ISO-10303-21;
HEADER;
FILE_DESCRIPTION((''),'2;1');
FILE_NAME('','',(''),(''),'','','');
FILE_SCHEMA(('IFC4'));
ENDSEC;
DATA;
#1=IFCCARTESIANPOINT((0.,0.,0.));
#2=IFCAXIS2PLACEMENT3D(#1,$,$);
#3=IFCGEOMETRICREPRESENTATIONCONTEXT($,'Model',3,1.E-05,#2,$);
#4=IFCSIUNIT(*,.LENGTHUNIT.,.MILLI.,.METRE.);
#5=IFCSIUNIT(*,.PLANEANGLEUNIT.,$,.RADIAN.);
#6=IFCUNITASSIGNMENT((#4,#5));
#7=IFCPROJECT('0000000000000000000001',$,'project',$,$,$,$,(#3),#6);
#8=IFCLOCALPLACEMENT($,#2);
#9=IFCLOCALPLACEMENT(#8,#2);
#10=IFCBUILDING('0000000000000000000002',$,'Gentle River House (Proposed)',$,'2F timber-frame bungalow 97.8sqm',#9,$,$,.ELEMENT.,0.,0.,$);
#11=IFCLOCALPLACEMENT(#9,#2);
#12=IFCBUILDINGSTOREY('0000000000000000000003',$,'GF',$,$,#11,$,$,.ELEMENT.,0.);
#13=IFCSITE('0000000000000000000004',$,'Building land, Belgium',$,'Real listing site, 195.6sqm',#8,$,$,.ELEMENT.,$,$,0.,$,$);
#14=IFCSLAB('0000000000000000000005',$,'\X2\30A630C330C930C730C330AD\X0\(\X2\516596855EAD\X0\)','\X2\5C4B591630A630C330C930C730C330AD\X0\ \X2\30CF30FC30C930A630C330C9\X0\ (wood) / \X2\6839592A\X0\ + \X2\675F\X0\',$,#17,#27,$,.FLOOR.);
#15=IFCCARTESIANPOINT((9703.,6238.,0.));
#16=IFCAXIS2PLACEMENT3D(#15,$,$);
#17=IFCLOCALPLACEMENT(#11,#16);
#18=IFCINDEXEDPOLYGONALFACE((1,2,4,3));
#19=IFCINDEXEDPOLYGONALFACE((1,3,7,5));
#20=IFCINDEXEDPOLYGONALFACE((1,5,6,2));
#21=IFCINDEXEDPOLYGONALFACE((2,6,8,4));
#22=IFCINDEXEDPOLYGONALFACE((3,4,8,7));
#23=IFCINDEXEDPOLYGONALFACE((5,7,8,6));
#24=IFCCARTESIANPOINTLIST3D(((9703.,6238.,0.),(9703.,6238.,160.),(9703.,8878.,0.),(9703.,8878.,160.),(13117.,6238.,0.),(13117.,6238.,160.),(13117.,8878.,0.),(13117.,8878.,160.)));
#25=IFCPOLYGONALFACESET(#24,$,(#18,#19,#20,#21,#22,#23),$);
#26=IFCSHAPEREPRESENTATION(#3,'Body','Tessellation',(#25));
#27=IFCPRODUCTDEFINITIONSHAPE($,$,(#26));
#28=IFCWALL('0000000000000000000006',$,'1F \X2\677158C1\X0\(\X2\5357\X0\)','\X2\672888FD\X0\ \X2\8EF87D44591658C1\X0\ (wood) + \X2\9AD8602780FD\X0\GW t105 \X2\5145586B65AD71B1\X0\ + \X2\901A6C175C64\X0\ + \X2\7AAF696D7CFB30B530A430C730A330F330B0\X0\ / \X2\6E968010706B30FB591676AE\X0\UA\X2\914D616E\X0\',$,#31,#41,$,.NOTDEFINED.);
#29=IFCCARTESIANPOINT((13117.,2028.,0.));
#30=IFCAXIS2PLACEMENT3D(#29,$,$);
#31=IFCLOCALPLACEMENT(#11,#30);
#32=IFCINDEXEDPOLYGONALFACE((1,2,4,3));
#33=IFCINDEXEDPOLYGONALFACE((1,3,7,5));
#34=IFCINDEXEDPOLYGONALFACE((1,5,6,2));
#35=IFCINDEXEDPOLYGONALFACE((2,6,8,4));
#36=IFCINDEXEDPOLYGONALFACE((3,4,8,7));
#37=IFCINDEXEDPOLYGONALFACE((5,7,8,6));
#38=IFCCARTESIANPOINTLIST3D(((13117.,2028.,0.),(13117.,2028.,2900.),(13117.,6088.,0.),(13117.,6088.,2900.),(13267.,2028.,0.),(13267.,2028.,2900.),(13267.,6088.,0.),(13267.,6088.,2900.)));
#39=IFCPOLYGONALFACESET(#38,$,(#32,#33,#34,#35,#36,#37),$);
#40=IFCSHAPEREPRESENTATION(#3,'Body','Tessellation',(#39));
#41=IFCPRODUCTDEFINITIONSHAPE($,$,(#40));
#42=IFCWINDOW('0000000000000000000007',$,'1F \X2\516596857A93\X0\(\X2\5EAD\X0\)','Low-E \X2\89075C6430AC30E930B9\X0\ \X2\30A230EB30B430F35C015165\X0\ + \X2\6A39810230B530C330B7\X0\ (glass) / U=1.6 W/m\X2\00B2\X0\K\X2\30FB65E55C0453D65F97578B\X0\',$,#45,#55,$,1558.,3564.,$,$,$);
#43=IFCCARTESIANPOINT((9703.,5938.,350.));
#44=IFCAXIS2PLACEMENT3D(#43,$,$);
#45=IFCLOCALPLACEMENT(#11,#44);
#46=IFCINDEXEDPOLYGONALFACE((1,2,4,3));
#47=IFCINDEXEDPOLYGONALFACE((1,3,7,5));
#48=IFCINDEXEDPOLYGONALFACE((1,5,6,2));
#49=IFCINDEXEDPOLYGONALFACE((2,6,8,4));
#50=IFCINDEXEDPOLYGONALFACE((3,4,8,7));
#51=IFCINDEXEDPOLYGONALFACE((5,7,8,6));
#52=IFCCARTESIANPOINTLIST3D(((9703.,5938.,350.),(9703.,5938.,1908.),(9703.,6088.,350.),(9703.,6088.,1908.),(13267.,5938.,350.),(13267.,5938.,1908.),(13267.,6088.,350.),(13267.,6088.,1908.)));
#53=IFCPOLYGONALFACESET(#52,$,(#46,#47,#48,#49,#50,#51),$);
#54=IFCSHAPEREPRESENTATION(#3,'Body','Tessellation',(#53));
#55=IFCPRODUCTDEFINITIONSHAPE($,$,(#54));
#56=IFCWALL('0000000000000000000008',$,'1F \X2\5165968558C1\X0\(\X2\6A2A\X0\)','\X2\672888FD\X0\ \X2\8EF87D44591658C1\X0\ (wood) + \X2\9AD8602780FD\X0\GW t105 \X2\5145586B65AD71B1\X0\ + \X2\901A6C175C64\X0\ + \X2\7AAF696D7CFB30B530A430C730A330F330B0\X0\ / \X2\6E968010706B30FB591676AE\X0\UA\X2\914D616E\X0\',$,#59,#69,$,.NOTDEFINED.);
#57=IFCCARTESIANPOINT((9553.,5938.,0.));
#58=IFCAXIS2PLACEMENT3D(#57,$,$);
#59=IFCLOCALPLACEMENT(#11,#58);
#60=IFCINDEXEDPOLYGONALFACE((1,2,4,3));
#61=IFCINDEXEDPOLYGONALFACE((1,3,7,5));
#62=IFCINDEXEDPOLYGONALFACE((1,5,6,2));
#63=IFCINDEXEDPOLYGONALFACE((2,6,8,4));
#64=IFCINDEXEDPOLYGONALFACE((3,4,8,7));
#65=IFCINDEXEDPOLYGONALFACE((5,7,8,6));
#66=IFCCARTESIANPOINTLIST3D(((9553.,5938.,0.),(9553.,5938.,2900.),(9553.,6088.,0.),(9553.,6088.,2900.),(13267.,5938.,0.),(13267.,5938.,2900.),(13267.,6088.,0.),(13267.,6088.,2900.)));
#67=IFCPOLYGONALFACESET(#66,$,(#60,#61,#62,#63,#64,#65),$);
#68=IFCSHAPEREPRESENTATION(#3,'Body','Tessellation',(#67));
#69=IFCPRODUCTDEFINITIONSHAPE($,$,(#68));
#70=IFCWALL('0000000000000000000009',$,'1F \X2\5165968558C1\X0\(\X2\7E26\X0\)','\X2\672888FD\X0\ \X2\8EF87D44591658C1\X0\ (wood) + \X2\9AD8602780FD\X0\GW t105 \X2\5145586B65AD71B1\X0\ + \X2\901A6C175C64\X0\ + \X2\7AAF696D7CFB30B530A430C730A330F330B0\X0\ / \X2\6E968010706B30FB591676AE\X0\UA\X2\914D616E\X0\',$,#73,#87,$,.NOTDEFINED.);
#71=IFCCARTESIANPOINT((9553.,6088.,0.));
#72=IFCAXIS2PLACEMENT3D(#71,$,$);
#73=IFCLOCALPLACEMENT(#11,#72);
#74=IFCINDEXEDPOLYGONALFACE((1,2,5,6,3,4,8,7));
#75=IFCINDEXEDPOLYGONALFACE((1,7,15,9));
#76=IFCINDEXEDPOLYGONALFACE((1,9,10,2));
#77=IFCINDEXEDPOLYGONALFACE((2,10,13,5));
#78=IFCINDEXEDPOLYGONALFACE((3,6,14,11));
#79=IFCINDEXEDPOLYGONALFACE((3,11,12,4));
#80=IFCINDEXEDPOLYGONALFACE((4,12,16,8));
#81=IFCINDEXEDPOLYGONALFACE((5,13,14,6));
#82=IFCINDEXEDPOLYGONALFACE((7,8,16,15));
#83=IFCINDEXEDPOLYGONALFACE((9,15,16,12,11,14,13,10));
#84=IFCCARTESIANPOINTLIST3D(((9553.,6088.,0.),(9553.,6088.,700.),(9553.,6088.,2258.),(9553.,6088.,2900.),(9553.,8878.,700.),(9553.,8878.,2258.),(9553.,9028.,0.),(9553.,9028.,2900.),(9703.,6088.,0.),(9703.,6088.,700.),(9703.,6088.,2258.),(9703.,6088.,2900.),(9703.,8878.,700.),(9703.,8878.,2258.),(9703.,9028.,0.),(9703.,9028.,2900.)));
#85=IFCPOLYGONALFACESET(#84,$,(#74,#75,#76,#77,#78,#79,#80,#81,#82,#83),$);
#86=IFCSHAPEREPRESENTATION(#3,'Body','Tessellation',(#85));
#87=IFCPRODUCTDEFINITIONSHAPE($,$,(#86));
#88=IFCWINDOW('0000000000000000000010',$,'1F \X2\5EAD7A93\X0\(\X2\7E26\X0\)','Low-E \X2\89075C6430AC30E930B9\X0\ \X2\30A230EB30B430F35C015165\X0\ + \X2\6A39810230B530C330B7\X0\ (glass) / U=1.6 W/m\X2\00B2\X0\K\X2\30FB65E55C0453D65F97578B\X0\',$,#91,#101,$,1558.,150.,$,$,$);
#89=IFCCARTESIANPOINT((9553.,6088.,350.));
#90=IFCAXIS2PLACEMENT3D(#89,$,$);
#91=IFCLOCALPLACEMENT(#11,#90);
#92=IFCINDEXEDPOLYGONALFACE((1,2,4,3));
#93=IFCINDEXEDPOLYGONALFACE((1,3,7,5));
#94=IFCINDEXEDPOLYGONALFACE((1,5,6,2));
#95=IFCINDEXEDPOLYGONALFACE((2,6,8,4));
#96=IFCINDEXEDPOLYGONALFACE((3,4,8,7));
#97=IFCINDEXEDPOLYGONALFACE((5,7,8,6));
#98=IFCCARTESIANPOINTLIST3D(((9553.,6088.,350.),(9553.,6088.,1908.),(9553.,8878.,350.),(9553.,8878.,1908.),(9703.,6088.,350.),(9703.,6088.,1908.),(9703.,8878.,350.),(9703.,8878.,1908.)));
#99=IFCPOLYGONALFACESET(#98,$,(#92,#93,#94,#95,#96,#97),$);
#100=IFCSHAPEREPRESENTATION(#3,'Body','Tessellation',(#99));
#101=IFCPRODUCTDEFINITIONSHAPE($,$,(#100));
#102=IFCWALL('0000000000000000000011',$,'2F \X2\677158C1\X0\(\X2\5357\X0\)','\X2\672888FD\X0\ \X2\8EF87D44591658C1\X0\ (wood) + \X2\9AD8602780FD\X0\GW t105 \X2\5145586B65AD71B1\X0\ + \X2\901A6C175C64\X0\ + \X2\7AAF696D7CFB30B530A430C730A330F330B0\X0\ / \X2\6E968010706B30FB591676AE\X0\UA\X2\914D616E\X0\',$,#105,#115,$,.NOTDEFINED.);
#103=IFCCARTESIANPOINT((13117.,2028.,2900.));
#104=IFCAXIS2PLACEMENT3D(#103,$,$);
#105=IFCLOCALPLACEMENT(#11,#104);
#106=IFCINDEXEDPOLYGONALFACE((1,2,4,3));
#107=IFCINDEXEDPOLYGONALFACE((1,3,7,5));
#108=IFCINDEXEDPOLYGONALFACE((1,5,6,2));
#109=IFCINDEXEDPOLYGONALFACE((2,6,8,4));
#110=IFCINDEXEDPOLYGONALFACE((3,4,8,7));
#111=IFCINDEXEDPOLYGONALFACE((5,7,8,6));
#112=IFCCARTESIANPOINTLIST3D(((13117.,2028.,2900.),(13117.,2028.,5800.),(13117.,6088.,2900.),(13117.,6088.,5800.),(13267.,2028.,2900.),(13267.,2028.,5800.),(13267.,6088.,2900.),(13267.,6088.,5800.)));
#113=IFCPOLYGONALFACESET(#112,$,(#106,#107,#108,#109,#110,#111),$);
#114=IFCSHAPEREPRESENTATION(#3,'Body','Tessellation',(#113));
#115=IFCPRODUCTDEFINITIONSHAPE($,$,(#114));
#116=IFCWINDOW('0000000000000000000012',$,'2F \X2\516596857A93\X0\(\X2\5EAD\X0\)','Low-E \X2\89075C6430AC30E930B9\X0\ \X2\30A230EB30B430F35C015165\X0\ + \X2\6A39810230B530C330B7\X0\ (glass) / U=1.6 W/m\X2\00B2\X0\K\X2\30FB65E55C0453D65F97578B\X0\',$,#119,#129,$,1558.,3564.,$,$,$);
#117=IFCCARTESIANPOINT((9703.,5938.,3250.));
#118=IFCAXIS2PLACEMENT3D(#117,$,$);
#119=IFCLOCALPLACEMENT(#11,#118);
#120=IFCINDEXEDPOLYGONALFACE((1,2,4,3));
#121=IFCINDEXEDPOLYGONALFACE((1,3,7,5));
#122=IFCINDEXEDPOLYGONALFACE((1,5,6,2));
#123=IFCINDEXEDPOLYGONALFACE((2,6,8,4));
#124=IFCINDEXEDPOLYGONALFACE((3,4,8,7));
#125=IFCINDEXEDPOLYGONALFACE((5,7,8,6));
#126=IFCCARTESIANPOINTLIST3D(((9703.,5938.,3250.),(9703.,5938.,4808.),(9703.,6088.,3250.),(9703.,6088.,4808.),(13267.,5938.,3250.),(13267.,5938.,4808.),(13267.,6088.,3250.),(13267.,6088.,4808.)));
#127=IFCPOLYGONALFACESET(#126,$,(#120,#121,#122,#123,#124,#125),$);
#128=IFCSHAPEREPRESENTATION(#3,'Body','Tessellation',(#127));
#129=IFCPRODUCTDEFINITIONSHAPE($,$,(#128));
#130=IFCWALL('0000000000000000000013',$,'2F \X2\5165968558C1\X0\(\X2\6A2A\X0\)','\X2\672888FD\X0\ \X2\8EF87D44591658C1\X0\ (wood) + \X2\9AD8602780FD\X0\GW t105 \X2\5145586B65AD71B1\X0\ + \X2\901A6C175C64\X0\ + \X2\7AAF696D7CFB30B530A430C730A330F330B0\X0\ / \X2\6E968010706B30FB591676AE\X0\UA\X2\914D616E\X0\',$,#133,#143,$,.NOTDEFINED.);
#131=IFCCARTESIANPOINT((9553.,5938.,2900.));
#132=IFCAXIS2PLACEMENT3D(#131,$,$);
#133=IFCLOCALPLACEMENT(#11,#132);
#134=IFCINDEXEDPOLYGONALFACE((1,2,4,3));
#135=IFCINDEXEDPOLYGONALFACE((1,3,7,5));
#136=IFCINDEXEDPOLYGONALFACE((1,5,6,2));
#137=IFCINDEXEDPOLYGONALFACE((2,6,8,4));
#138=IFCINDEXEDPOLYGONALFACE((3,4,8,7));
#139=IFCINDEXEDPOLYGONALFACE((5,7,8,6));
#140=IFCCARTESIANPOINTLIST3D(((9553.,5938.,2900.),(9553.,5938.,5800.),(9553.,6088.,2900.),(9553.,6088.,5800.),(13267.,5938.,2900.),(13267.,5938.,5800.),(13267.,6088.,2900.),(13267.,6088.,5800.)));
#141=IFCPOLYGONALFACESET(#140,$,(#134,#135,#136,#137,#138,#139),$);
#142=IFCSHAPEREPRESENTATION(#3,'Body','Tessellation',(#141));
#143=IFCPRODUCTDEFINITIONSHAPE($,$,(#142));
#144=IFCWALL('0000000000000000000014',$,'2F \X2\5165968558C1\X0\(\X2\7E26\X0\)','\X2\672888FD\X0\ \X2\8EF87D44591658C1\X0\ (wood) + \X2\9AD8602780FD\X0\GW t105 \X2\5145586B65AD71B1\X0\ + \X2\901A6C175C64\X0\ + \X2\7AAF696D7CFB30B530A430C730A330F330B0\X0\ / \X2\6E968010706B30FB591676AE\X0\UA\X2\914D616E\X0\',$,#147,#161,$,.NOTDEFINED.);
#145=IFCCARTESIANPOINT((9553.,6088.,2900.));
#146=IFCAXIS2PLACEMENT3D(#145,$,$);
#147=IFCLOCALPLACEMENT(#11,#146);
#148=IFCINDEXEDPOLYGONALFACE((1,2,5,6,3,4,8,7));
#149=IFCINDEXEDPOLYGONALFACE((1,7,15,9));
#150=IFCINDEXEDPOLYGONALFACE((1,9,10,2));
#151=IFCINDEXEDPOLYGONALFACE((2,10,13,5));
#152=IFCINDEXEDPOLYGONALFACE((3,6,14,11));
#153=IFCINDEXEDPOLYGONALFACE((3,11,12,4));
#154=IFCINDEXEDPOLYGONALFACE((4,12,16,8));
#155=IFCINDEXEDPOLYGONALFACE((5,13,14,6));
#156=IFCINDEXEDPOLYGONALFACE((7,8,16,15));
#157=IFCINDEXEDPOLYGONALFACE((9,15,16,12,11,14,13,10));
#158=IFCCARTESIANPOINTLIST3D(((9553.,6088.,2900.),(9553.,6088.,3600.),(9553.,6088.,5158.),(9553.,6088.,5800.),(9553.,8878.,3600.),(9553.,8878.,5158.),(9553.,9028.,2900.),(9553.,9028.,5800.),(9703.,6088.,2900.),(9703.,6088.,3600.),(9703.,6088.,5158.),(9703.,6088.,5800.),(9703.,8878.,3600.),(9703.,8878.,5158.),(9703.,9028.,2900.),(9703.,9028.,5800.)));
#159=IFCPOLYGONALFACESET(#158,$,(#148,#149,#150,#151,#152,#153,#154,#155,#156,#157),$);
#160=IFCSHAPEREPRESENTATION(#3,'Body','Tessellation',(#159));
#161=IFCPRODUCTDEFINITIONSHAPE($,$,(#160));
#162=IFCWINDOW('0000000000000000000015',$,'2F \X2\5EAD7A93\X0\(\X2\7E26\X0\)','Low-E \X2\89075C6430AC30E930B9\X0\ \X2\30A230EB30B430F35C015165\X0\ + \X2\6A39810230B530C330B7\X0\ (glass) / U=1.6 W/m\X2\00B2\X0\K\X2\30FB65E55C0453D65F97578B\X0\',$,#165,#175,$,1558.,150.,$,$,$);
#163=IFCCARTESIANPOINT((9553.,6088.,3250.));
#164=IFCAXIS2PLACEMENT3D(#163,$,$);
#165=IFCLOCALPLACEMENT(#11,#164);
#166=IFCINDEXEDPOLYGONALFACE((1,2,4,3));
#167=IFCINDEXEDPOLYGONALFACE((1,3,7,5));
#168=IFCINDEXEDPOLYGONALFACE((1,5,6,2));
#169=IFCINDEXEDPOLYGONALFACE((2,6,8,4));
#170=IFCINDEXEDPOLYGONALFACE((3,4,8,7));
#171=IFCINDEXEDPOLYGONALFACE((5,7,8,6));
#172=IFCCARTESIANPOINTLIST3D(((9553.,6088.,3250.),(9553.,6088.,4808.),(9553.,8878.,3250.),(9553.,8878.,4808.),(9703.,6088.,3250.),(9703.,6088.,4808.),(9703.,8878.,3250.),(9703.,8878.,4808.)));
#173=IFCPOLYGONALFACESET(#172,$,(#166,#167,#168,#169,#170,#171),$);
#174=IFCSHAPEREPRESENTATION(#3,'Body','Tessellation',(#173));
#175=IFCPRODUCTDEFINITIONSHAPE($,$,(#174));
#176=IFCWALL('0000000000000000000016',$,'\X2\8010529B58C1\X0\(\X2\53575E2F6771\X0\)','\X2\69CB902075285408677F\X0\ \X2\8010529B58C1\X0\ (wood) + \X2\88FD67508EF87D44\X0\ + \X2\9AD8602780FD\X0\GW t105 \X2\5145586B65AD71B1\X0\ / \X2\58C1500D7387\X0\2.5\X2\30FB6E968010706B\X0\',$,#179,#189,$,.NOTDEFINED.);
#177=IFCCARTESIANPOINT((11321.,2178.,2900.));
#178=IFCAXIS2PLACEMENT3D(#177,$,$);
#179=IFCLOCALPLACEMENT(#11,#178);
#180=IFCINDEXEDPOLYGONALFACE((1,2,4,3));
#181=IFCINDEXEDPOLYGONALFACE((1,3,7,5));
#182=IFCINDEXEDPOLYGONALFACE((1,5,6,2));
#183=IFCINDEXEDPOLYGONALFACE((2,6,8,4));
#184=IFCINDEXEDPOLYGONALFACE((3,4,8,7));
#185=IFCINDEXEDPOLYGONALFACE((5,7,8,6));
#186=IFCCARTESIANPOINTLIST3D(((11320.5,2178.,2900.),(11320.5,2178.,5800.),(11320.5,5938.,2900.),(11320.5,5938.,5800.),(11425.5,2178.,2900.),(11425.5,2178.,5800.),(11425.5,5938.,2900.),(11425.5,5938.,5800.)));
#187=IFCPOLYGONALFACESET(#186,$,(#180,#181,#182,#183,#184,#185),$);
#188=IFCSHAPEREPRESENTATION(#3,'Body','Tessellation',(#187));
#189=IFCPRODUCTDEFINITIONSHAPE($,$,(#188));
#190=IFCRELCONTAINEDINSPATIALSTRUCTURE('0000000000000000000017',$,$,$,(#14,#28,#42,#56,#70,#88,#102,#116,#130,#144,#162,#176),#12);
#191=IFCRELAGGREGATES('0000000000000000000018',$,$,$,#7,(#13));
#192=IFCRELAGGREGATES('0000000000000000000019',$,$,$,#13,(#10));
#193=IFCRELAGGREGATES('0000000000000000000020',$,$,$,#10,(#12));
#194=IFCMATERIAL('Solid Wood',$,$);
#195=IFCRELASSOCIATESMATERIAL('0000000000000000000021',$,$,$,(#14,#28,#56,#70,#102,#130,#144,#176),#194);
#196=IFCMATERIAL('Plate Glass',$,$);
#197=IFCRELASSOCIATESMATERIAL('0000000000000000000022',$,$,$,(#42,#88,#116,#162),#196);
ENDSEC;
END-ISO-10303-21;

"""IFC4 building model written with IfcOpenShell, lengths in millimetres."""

from ifc_helpers import new_model, si_unit, frame, frame_2d, origin, place, context, project, spatial, rectangle, extrude, material, element, fill, save


model = new_model("IFC4")

# Units and contexts
model_context = context("Model", 3, precision=1e-05, world=origin())
ifc_project = project(units=[si_unit("LENGTHUNIT", "METRE", prefix="MILLI"), si_unit("PLANEANGLEUNIT", "RADIAN")], contexts=[model_context])

# Site, building, storey
site_placement = place(None, origin())
site = spatial("IfcSite", under=ifc_project, at=site_placement, Name="Building land, Belgium", ObjectType="Real listing site, 195.6sqm", CompositionType="ELEMENT", RefElevation=0.0)
building_placement = place(site_placement, origin())
building = spatial("IfcBuilding", under=site, at=building_placement, Name="Gentle River House (Proposed)", ObjectType="2F timber-frame bungalow 97.8sqm", CompositionType="ELEMENT", ElevationOfRefHeight=0.0, ElevationOfTerrain=0.0)
storey_placement = place(building_placement, origin())
storey = spatial("IfcBuildingStorey", under=building, at=storey_placement, Name="GF", CompositionType="ELEMENT", Elevation=0.0)

# Slab
ifc_material_1 = material(Name="Solid Wood")
slab_placement = place(storey_placement, frame((9703.0, 6238.0, 0.0)))
element("IfcSlab", 1, at=slab_placement, inside=storey, material=ifc_material_1, Name="ウッドデッキ(入隅庭)", Description="屋外ウッドデッキ ハードウッド (wood) / 根太 + 束", PredefinedType="FLOOR", context=model_context, shape_type="SweptSolid", body=[
    extrude(rectangle(XDim=3414.0, YDim=2640.0, at=frame_2d((1707.0, 1320.0))), frame((9703.0, 6238.0, 0.0)), (0.0, 0.0, 1.0), 160.0),
])

# Wall, opening, window
wall_1_placement = place(storey_placement, frame((13117.0, 2028.0, 0.0)))
wall_1 = element("IfcWall", 2, at=wall_1_placement, inside=storey, material=ifc_material_1, Name="1F 東壁(南)", Description="木製 軸組外壁 (wood) + 高性能GW t105 充填断熱 + 通気層 + 窯業系サイディング / 準耐火・外皮UA配慮", PredefinedType="NOTDEFINED", context=model_context, shape_type="SweptSolid", body=[
    extrude(rectangle(XDim=150.0, YDim=4060.0, at=frame_2d((75.0, 2030.0))), frame((13117.0, 2028.0, 0.0)), (0.0, 0.0, 1.0), 2900.0),
])
opening_1_placement = place(storey_placement, frame((9703.0, 5938.0, 350.0)))
opening_1 = element("IfcOpeningElement", 3, at=opening_1_placement, cuts=wall_1, PredefinedType="NOTDEFINED", context=model_context, shape_type="SweptSolid", body=[
    extrude(rectangle(XDim=3564.0, YDim=150.0, at=frame_2d((1782.0, 75.0))), frame((9703.0, 5938.0, 350.0)), (0.0, 0.0, 1.0), 1558.0),
])
ifc_material_2 = material(Name="Plate Glass")
window_1_placement = place(storey_placement, frame((9703.0, 5938.0, 350.0)))
window_1 = element("IfcWindow", 4, at=window_1_placement, inside=storey, material=ifc_material_2, Name="1F 入隅窓(庭)", Description="Low-E 複層ガラス アルゴン封入 + 樹脂サッシ (glass) / U=1.6 W/m²K・日射取得型", OverallHeight=1558.0, OverallWidth=3564.0, context=model_context, shape_type="SweptSolid", body=[
    extrude(rectangle(XDim=3564.0, YDim=150.0, at=frame_2d((1782.0, 75.0))), frame((9703.0, 5938.0, 350.0)), (0.0, 0.0, 1.0), 1558.0),
])
fill(opening_1, window_1)

# Wall
wall_2_placement = place(storey_placement, frame((9553.0, 5938.0, 0.0)))
element("IfcWall", 5, at=wall_2_placement, inside=storey, material=ifc_material_1, Name="1F 入隅壁(横)", Description="木製 軸組外壁 (wood) + 高性能GW t105 充填断熱 + 通気層 + 窯業系サイディング / 準耐火・外皮UA配慮", PredefinedType="NOTDEFINED", context=model_context, shape_type="SweptSolid", body=[
    extrude(rectangle(XDim=3714.0, YDim=150.0, at=frame_2d((1857.0, 75.0))), frame((9553.0, 5938.0, 0.0)), (0.0, 0.0, 1.0), 2900.0),
])

# Wall, opening, window
wall_3_placement = place(storey_placement, frame((9553.0, 6088.0, 0.0)))
wall_3 = element("IfcWall", 6, at=wall_3_placement, inside=storey, material=ifc_material_1, Name="1F 入隅壁(縦)", Description="木製 軸組外壁 (wood) + 高性能GW t105 充填断熱 + 通気層 + 窯業系サイディング / 準耐火・外皮UA配慮", PredefinedType="NOTDEFINED", context=model_context, shape_type="SweptSolid", body=[
    extrude(rectangle(XDim=150.0, YDim=2940.0, at=frame_2d((75.0, 1470.0))), frame((9553.0, 6088.0, 0.0)), (0.0, 0.0, 1.0), 2900.0),
])
opening_2_placement = place(storey_placement, frame((9553.0, 6088.0, 350.0)))
opening_2 = element("IfcOpeningElement", 7, at=opening_2_placement, cuts=wall_3, PredefinedType="NOTDEFINED", context=model_context, shape_type="SweptSolid", body=[
    extrude(rectangle(XDim=150.0, YDim=2790.0, at=frame_2d((75.0, 1395.0))), frame((9553.0, 6088.0, 350.0)), (0.0, 0.0, 1.0), 1558.0),
])
window_2_placement = place(storey_placement, frame((9553.0, 6088.0, 350.0)))
window_2 = element("IfcWindow", 8, at=window_2_placement, inside=storey, material=ifc_material_2, Name="1F 庭窓(縦)", Description="Low-E 複層ガラス アルゴン封入 + 樹脂サッシ (glass) / U=1.6 W/m²K・日射取得型", OverallHeight=1558.0, OverallWidth=150.0, context=model_context, shape_type="SweptSolid", body=[
    extrude(rectangle(XDim=150.0, YDim=2790.0, at=frame_2d((75.0, 1395.0))), frame((9553.0, 6088.0, 350.0)), (0.0, 0.0, 1.0), 1558.0),
])
fill(opening_2, window_2)

# Wall, opening, window
wall_4_placement = place(storey_placement, frame((13117.0, 2028.0, 2900.0)))
wall_4 = element("IfcWall", 9, at=wall_4_placement, inside=storey, material=ifc_material_1, Name="2F 東壁(南)", Description="木製 軸組外壁 (wood) + 高性能GW t105 充填断熱 + 通気層 + 窯業系サイディング / 準耐火・外皮UA配慮", PredefinedType="NOTDEFINED", context=model_context, shape_type="SweptSolid", body=[
    extrude(rectangle(XDim=150.0, YDim=4060.0, at=frame_2d((75.0, 2030.0))), frame((13117.0, 2028.0, 2900.0)), (0.0, 0.0, 1.0), 2900.0),
])
opening_3_placement = place(storey_placement, frame((9703.0, 5938.0, 3250.0)))
opening_3 = element("IfcOpeningElement", 10, at=opening_3_placement, cuts=wall_4, PredefinedType="NOTDEFINED", context=model_context, shape_type="SweptSolid", body=[
    extrude(rectangle(XDim=3564.0, YDim=150.0, at=frame_2d((1782.0, 75.0))), frame((9703.0, 5938.0, 3250.0)), (0.0, 0.0, 1.0), 1558.0),
])
window_3_placement = place(storey_placement, frame((9703.0, 5938.0, 3250.0)))
window_3 = element("IfcWindow", 11, at=window_3_placement, inside=storey, material=ifc_material_2, Name="2F 入隅窓(庭)", Description="Low-E 複層ガラス アルゴン封入 + 樹脂サッシ (glass) / U=1.6 W/m²K・日射取得型", OverallHeight=1558.0, OverallWidth=3564.0, context=model_context, shape_type="SweptSolid", body=[
    extrude(rectangle(XDim=3564.0, YDim=150.0, at=frame_2d((1782.0, 75.0))), frame((9703.0, 5938.0, 3250.0)), (0.0, 0.0, 1.0), 1558.0),
])
fill(opening_3, window_3)

# Wall
wall_5_placement = place(storey_placement, frame((9553.0, 5938.0, 2900.0)))
element("IfcWall", 12, at=wall_5_placement, inside=storey, material=ifc_material_1, Name="2F 入隅壁(横)", Description="木製 軸組外壁 (wood) + 高性能GW t105 充填断熱 + 通気層 + 窯業系サイディング / 準耐火・外皮UA配慮", PredefinedType="NOTDEFINED", context=model_context, shape_type="SweptSolid", body=[
    extrude(rectangle(XDim=3714.0, YDim=150.0, at=frame_2d((1857.0, 75.0))), frame((9553.0, 5938.0, 2900.0)), (0.0, 0.0, 1.0), 2900.0),
])

# Wall, opening, window
wall_6_placement = place(storey_placement, frame((9553.0, 6088.0, 2900.0)))
wall_6 = element("IfcWall", 13, at=wall_6_placement, inside=storey, material=ifc_material_1, Name="2F 入隅壁(縦)", Description="木製 軸組外壁 (wood) + 高性能GW t105 充填断熱 + 通気層 + 窯業系サイディング / 準耐火・外皮UA配慮", PredefinedType="NOTDEFINED", context=model_context, shape_type="SweptSolid", body=[
    extrude(rectangle(XDim=150.0, YDim=2940.0, at=frame_2d((75.0, 1470.0))), frame((9553.0, 6088.0, 2900.0)), (0.0, 0.0, 1.0), 2900.0),
])
opening_4_placement = place(storey_placement, frame((9553.0, 6088.0, 3250.0)))
opening_4 = element("IfcOpeningElement", 14, at=opening_4_placement, cuts=wall_6, PredefinedType="NOTDEFINED", context=model_context, shape_type="SweptSolid", body=[
    extrude(rectangle(XDim=150.0, YDim=2790.0, at=frame_2d((75.0, 1395.0))), frame((9553.0, 6088.0, 3250.0)), (0.0, 0.0, 1.0), 1558.0),
])
window_4_placement = place(storey_placement, frame((9553.0, 6088.0, 3250.0)))
window_4 = element("IfcWindow", 15, at=window_4_placement, inside=storey, material=ifc_material_2, Name="2F 庭窓(縦)", Description="Low-E 複層ガラス アルゴン封入 + 樹脂サッシ (glass) / U=1.6 W/m²K・日射取得型", OverallHeight=1558.0, OverallWidth=150.0, context=model_context, shape_type="SweptSolid", body=[
    extrude(rectangle(XDim=150.0, YDim=2790.0, at=frame_2d((75.0, 1395.0))), frame((9553.0, 6088.0, 3250.0)), (0.0, 0.0, 1.0), 1558.0),
])
fill(opening_4, window_4)

# Wall
wall_7_placement = place(storey_placement, frame((11321.0, 2178.0, 2900.0)))
element("IfcWall", 16, at=wall_7_placement, inside=storey, material=ifc_material_1, Name="耐力壁(南帯東)", Description="構造用合板 耐力壁 (wood) + 製材軸組 + 高性能GW t105 充填断熱 / 壁倍率2.5・準耐火", PredefinedType="NOTDEFINED", context=model_context, shape_type="SweptSolid", body=[
    extrude(rectangle(XDim=105.0, YDim=3760.0, at=frame_2d((52.0, 1880.0))), frame((11321.0, 2178.0, 2900.0)), (0.0, 0.0, 1.0), 2900.0),
])

save(model, "model.ifc")
